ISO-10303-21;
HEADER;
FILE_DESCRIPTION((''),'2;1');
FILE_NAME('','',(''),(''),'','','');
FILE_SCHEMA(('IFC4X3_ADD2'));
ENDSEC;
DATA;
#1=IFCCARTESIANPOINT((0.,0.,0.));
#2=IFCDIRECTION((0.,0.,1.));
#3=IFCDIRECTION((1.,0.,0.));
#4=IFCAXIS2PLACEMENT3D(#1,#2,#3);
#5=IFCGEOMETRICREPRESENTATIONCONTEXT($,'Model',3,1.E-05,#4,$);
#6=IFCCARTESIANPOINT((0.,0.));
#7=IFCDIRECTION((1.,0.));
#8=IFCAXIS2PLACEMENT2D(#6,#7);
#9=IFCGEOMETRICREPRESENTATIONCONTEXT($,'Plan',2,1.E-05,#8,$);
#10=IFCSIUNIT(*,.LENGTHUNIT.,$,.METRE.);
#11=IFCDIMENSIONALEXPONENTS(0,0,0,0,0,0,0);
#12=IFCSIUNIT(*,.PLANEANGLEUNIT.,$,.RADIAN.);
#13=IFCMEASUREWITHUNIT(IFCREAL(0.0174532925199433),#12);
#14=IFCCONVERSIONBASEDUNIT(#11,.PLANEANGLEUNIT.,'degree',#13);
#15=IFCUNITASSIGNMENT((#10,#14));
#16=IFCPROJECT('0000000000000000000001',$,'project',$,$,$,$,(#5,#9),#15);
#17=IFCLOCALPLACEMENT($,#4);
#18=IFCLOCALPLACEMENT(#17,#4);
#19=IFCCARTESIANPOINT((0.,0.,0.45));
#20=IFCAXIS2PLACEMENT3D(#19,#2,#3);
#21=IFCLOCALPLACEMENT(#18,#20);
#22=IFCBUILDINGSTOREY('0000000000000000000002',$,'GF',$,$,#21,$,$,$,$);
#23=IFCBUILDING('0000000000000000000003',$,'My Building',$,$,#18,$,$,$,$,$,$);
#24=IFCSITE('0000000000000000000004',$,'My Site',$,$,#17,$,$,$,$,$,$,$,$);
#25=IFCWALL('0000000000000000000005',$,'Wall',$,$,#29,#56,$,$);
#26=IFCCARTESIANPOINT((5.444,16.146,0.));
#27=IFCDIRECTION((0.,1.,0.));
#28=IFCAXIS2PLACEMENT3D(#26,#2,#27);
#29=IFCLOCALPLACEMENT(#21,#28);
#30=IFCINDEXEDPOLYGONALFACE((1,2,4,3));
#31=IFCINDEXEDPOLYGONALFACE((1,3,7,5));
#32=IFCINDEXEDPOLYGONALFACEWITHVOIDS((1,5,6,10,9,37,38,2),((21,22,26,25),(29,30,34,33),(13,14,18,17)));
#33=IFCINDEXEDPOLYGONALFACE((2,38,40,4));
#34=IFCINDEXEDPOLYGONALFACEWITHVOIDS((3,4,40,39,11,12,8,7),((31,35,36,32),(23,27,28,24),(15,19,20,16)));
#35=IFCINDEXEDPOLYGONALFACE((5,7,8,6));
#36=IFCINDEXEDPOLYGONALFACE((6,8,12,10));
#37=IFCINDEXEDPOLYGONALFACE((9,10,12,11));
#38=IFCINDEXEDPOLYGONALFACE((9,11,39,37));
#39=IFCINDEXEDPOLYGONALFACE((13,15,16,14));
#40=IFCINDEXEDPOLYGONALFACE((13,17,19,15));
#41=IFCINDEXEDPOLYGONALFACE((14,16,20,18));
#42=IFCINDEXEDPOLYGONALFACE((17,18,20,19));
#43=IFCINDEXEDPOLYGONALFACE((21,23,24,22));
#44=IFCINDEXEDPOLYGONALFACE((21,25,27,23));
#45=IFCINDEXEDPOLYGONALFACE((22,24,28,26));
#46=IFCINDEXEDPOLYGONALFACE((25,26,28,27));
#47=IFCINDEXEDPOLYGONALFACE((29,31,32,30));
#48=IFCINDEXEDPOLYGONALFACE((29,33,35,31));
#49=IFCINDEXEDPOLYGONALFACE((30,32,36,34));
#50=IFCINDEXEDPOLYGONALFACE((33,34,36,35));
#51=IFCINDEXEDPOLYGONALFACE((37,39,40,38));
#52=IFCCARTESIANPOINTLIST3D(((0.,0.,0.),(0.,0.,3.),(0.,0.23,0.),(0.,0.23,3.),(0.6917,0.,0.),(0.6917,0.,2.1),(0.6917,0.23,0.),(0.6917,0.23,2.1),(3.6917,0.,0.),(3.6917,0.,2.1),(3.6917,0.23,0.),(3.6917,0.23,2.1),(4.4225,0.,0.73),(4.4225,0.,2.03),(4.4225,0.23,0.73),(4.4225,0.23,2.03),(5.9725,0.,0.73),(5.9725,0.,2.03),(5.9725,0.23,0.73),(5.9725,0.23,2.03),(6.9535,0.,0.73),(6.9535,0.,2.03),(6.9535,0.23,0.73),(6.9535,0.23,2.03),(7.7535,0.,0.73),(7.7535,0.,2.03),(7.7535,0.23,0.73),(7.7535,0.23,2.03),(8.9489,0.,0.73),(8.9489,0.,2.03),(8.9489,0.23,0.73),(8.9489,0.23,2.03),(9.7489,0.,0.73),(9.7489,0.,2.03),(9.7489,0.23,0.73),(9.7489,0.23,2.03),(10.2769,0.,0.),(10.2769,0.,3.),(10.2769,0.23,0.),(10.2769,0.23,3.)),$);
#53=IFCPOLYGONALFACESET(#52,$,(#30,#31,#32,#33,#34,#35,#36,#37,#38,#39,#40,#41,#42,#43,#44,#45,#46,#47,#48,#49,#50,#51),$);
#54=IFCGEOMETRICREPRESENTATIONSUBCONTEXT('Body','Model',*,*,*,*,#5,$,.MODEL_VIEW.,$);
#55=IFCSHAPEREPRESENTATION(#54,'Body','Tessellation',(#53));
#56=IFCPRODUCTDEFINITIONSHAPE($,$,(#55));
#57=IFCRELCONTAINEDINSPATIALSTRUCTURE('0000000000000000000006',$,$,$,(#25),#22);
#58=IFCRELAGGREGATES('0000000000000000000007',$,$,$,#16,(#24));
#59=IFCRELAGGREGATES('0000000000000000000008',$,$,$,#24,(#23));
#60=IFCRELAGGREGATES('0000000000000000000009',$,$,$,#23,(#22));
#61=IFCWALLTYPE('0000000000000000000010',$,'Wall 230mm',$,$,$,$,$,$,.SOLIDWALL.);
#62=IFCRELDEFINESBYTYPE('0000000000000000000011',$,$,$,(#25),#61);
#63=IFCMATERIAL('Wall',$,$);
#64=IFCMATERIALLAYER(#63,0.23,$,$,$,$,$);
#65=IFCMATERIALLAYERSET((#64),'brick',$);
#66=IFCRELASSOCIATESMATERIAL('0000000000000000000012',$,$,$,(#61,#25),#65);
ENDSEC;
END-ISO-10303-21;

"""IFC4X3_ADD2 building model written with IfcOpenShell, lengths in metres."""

from ifc_helpers import new_model, entity, si_unit, converted_unit, frame, origin_with_axes, origin_2d_with_axis, place, context, subcontext, project, spatial, line, indexed_curve, outline, extrude, source, transform, mapped, material, layer, layer_set, layer_usage, type_object, element, save


model = new_model("IFC4X3_ADD2")

# Units and contexts
model_context = context("Model", 3, precision=1e-05, world=origin_with_axes())
plan_context = context("Plan", 2, precision=1e-05, world=origin_2d_with_axis())
body_context_1 = subcontext(model_context, "Body", "Model", "MODEL_VIEW")
ifc_project = project(units=[si_unit("LENGTHUNIT", "METRE"), converted_unit("PLANEANGLEUNIT", "degree", entity("IfcReal", 0.0174532925199433), si_unit("PLANEANGLEUNIT", "RADIAN"), dimensions=[0, 0, 0, 0, 0, 0, 0])], contexts=[model_context, plan_context])

# Site, building, storey
site_placement = place(None, origin_with_axes())
site = spatial("IfcSite", under=ifc_project, at=site_placement, Name="My Site")
building_placement = place(site_placement, origin_with_axes())
building = spatial("IfcBuilding", under=site, at=building_placement, Name="My Building")
storey_placement = place(building_placement, frame((0.0, 0.0, 0.45), z_axis=(0.0, 0.0, 1.0), x_axis=(1.0, 0.0, 0.0)))
storey = spatial("IfcBuildingStorey", under=building, at=storey_placement, Name="GF")

# Wall, openings
ifc_material_1 = material(Name="Wall")
ifc_layer_1 = layer(ifc_material_1, 0.23)
ifc_layer_set_1 = layer_set([ifc_layer_1], Name="brick")
ifc_layer_usage_1 = layer_usage(ifc_layer_set_1, "AXIS2", "POSITIVE", 0.0)
wall_type_1 = type_object("IfcWallType", Name="Wall 230mm", PredefinedType="SOLIDWALL", material=ifc_layer_set_1)
wall_1_placement = place(storey_placement, frame((5.444, 16.146, 0.0), z_axis=(0.0, 0.0, 1.0), x_axis=(0.0, 1.0, 0.0)))
wall_1 = element("IfcWall", 1, at=wall_1_placement, inside=storey, type_object=wall_type_1, material=ifc_layer_usage_1, Name="Wall", context=body_context_1, shape_type="SweptSolid", body=[
    extrude(outline(indexed_curve([(0.0, 0.0), (0.0, 0.23), (10.2769, 0.23), (10.2769, 0.0), (0.0, 0.0)], self_intersect=False)), origin_with_axes(), (0.0, 0.0, 1.0), 3.0),
])
shared_shape_1 = source(origin_with_axes(), body_context_1, "Body", "SweptSolid", [
    extrude(outline(indexed_curve([(0.0, 0.0), (3.0, 0.0), (3.0, 2.1), (0.0, 2.1)], segments=[line(1, 2, 3, 4, 1)])), frame((0.0, -0.6, 0.0), z_axis=(0.0, -1.0, 0.0), x_axis=(1.0, 0.0, 0.0)), (0.0, 0.0, -1.0), 1.2),
])
opening_1_placement = place(wall_1_placement, frame((0.6917, 0.0, 0.0), z_axis=(0.0, 0.0, 1.0), x_axis=(1.0, 0.0, 0.0)))
element("IfcOpeningElement", 2, at=opening_1_placement, cuts=wall_1, PredefinedType="OPENING", context=body_context_1, shape_type="MappedRepresentation", body=[
    mapped(shared_shape_1, transform((0.0, 0.0, 0.0), x_axis=(1.0, 0.0, 0.0), y_axis=(0.0, 1.0, 0.0), z_axis=(0.0, 0.0, 1.0), scale=1.0)),
])
shared_shape_2 = source(origin_with_axes(), body_context_1, "Body", "SweptSolid", [
    extrude(outline(indexed_curve([(0.0, 0.0), (0.8, 0.0), (0.8, 1.3), (0.0, 1.3)], segments=[line(1, 2, 3, 4, 1)])), frame((-0.4, -0.6, 0.0), z_axis=(0.0, -1.0, 0.0), x_axis=(1.0, 0.0, 0.0)), (0.0, 0.0, -1.0), 1.2),
])
opening_2_placement = place(wall_1_placement, frame((7.3535, 0.0, 0.73), z_axis=(0.0, 0.0, 1.0), x_axis=(1.0, 0.0, 0.0)))
element("IfcOpeningElement", 3, at=opening_2_placement, cuts=wall_1, PredefinedType="OPENING", context=body_context_1, shape_type="MappedRepresentation", body=[
    mapped(shared_shape_2, transform((0.0, 0.0, 0.0), x_axis=(1.0, 0.0, 0.0), y_axis=(0.0, 1.0, 0.0), z_axis=(0.0, 0.0, 1.0), scale=1.0)),
])
shared_shape_3 = source(origin_with_axes(), body_context_1, "Body", "SweptSolid", [
    extrude(outline(indexed_curve([(0.0, 0.0), (1.55, 0.0), (1.55, 1.3), (0.0, 1.3)], segments=[line(1, 2, 3, 4, 1)])), frame((-0.775, -0.6, 0.0), z_axis=(0.0, -1.0, 0.0), x_axis=(1.0, 0.0, 0.0)), (0.0, 0.0, -1.0), 1.2),
])
opening_3_placement = place(wall_1_placement, frame((5.1975, 0.0, 0.73), z_axis=(0.0, 0.0, 1.0), x_axis=(1.0, 0.0, 0.0)))
element("IfcOpeningElement", 4, at=opening_3_placement, cuts=wall_1, PredefinedType="OPENING", context=body_context_1, shape_type="MappedRepresentation", body=[
    mapped(shared_shape_3, transform((0.0, 0.0, 0.0), x_axis=(1.0, 0.0, 0.0), y_axis=(0.0, 1.0, 0.0), z_axis=(0.0, 0.0, 1.0), scale=1.0)),
])
opening_4_placement = place(wall_1_placement, frame((9.3489, 0.0, 0.73), z_axis=(0.0, 0.0, 1.0), x_axis=(1.0, 0.0, 0.0)))
element("IfcOpeningElement", 5, at=opening_4_placement, cuts=wall_1, PredefinedType="OPENING", context=body_context_1, shape_type="MappedRepresentation", body=[
    mapped(shared_shape_2, transform((0.0, 0.0, 0.0), x_axis=(1.0, 0.0, 0.0), y_axis=(0.0, 1.0, 0.0), z_axis=(0.0, 0.0, 1.0), scale=1.0)),
])

save(model, "model.ifc")
